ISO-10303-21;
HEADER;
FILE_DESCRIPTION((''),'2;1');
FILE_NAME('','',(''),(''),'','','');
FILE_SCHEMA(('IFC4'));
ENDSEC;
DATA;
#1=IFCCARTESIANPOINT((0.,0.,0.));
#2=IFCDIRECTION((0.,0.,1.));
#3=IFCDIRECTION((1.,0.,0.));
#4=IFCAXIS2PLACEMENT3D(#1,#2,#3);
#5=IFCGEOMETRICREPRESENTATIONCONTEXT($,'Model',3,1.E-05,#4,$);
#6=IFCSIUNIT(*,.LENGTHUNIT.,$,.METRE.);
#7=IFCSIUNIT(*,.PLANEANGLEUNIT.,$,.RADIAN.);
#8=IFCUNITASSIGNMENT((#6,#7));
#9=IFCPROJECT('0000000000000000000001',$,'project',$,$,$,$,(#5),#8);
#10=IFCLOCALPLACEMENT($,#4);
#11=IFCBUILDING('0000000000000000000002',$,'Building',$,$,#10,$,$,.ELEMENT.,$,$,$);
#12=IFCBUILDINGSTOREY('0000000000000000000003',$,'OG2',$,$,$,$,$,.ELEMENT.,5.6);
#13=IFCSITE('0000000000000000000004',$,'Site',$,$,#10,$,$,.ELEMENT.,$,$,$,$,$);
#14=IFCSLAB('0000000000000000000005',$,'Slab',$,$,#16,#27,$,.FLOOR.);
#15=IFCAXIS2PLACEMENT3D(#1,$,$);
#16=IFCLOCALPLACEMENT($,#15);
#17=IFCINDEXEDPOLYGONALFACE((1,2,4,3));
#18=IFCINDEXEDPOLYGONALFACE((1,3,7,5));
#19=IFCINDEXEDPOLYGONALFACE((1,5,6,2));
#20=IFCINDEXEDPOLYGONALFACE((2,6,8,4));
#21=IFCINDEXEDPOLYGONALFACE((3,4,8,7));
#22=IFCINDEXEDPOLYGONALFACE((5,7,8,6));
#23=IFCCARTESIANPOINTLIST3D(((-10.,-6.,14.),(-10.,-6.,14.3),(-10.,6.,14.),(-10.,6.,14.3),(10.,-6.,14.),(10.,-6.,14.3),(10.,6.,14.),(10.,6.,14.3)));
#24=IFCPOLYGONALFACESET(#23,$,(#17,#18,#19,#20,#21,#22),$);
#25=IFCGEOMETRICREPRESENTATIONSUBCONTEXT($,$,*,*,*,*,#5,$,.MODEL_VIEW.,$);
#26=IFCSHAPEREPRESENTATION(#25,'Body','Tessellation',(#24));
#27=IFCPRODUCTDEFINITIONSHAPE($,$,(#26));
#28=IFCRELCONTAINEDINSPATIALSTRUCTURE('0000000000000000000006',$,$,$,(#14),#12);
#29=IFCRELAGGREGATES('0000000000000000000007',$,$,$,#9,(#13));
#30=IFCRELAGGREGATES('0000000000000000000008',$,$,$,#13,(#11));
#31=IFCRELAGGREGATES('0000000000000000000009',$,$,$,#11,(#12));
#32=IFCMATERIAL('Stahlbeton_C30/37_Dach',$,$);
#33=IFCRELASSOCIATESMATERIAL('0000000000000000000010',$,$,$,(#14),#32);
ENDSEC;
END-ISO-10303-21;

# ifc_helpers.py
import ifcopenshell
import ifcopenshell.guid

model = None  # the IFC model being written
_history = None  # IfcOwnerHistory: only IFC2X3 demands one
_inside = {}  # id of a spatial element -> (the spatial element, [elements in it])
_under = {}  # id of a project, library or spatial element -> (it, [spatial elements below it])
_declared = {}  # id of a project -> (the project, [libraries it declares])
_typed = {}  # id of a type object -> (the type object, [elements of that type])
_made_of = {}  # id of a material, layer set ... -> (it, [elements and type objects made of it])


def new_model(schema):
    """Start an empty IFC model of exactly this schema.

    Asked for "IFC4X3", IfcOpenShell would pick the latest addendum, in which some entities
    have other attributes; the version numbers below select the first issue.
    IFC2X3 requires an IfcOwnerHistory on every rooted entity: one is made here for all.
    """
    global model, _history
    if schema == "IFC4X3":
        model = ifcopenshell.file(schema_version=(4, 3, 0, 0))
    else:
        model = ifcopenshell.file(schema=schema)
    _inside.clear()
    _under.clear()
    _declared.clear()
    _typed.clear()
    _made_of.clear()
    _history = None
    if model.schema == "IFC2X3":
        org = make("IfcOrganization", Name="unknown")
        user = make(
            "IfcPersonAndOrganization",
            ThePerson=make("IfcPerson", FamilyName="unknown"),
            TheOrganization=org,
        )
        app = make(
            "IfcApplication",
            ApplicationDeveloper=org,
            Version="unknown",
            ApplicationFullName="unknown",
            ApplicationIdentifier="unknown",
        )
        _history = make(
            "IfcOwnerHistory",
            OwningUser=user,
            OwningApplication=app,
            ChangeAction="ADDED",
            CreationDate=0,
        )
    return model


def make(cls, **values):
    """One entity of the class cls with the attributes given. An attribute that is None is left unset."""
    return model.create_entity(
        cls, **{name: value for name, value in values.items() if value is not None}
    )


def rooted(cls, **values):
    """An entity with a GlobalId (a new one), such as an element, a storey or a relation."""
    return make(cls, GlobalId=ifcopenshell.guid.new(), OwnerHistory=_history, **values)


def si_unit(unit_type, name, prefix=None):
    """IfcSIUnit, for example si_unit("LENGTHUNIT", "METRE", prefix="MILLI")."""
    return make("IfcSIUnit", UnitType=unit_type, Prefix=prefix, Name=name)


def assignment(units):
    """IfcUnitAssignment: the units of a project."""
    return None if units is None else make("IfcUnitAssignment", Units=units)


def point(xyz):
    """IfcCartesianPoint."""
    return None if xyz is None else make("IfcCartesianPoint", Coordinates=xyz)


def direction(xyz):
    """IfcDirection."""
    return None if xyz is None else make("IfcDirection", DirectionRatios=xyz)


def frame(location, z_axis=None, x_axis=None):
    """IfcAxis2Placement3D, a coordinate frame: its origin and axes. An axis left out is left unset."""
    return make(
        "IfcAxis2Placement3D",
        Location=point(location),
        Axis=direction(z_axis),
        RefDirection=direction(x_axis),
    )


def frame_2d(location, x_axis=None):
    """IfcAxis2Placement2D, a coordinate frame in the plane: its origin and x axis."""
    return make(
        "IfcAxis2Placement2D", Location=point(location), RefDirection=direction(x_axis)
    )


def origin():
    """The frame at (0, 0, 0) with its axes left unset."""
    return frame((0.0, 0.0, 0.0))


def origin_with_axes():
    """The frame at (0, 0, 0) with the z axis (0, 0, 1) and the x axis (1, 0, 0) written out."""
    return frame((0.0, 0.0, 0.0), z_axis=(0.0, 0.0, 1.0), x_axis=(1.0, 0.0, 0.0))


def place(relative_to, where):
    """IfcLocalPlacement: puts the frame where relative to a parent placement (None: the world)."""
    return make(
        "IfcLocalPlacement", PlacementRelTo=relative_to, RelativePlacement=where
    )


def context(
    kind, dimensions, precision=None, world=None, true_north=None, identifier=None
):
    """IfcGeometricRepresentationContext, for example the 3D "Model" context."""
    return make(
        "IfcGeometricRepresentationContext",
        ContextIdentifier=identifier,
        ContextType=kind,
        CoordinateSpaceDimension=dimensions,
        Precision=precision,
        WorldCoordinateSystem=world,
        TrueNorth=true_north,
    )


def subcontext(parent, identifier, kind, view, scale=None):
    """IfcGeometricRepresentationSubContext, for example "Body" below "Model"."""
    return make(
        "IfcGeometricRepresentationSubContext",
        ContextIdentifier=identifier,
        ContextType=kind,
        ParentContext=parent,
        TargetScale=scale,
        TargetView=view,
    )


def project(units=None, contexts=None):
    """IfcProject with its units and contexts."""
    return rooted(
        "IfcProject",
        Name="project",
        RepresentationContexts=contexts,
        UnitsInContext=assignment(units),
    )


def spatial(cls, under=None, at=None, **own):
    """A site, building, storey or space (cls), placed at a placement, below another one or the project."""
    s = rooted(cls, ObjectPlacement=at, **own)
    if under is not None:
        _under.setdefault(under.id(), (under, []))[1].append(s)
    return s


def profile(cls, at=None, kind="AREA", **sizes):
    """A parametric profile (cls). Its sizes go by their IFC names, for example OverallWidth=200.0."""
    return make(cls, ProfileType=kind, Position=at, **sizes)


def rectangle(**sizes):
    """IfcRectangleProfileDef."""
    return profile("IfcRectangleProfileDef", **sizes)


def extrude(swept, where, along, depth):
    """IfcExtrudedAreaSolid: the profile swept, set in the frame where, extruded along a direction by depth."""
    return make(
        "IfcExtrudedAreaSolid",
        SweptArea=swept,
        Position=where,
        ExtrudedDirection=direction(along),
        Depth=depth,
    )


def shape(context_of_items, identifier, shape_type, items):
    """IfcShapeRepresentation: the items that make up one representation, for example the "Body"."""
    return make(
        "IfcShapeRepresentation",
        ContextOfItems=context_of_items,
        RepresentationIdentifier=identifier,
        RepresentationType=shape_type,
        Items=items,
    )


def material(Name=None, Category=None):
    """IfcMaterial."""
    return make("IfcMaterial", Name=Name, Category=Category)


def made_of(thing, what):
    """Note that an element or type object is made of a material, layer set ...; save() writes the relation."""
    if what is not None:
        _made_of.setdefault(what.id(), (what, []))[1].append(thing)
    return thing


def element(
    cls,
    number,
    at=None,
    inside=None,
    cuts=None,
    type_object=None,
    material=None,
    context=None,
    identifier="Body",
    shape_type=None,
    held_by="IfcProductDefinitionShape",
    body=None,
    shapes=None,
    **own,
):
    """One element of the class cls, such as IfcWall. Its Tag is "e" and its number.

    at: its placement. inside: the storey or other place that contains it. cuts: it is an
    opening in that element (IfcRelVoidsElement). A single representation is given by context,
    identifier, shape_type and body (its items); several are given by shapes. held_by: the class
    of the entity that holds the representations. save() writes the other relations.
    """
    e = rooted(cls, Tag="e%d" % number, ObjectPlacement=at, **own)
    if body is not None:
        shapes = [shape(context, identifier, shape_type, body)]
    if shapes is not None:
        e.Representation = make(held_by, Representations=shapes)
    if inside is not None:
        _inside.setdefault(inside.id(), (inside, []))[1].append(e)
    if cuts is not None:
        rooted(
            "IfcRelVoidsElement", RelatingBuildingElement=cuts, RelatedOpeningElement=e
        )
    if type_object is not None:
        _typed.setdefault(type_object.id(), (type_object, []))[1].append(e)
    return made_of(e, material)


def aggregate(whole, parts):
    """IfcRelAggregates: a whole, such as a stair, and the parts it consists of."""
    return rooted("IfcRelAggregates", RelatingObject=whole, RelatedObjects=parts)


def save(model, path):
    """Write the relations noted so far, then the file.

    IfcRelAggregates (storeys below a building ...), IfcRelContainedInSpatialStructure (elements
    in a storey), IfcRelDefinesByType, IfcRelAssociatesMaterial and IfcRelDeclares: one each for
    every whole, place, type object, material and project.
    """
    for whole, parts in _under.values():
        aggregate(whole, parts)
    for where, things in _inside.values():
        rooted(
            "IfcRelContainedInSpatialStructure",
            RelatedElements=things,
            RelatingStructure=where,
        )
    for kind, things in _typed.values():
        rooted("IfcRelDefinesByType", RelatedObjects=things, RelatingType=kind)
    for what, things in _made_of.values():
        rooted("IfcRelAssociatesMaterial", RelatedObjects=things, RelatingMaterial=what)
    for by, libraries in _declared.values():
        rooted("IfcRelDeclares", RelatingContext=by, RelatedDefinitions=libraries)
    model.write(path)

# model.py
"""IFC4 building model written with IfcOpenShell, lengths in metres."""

from ifc_helpers import new_model, si_unit, frame, frame_2d, origin, origin_with_axes, place, context, subcontext, project, spatial, rectangle, extrude, material, element, save


model = new_model("IFC4")

# Units and contexts
model_context = context("Model", 3, precision=1e-05, world=origin_with_axes())
sub_context = subcontext(model_context, None, None, "MODEL_VIEW")
ifc_project = project(units=[si_unit("LENGTHUNIT", "METRE"), si_unit("PLANEANGLEUNIT", "RADIAN")], contexts=[model_context])

# Site, building, storey
placement_1 = place(None, origin_with_axes())
site = spatial("IfcSite", under=ifc_project, at=placement_1, Name="Site", CompositionType="ELEMENT")
building = spatial("IfcBuilding", under=site, at=placement_1, Name="Building", CompositionType="ELEMENT")
storey = spatial("IfcBuildingStorey", under=building, Name="OG2", CompositionType="ELEMENT", Elevation=5.6)

# Slab
ifc_material = material(Name="Stahlbeton_C30/37_Dach")
placement_2 = place(None, origin_with_axes())
placement_3 = place(placement_2, frame((0.0, 0.0, 5.6)))
slab_placement = place(placement_3, frame((-10.0, -6.0, 8.4)))
element("IfcSlab", 1, at=slab_placement, inside=storey, material=ifc_material, Name="Slab", PredefinedType="FLOOR", context=sub_context, shape_type="SweptSolid", body=[
    extrude(rectangle(XDim=20.0, YDim=12.0, at=frame_2d((10.0, 6.0))), origin(), (0.0, 0.0, 1.0), 0.3),
])

save(model, "model.ifc")
